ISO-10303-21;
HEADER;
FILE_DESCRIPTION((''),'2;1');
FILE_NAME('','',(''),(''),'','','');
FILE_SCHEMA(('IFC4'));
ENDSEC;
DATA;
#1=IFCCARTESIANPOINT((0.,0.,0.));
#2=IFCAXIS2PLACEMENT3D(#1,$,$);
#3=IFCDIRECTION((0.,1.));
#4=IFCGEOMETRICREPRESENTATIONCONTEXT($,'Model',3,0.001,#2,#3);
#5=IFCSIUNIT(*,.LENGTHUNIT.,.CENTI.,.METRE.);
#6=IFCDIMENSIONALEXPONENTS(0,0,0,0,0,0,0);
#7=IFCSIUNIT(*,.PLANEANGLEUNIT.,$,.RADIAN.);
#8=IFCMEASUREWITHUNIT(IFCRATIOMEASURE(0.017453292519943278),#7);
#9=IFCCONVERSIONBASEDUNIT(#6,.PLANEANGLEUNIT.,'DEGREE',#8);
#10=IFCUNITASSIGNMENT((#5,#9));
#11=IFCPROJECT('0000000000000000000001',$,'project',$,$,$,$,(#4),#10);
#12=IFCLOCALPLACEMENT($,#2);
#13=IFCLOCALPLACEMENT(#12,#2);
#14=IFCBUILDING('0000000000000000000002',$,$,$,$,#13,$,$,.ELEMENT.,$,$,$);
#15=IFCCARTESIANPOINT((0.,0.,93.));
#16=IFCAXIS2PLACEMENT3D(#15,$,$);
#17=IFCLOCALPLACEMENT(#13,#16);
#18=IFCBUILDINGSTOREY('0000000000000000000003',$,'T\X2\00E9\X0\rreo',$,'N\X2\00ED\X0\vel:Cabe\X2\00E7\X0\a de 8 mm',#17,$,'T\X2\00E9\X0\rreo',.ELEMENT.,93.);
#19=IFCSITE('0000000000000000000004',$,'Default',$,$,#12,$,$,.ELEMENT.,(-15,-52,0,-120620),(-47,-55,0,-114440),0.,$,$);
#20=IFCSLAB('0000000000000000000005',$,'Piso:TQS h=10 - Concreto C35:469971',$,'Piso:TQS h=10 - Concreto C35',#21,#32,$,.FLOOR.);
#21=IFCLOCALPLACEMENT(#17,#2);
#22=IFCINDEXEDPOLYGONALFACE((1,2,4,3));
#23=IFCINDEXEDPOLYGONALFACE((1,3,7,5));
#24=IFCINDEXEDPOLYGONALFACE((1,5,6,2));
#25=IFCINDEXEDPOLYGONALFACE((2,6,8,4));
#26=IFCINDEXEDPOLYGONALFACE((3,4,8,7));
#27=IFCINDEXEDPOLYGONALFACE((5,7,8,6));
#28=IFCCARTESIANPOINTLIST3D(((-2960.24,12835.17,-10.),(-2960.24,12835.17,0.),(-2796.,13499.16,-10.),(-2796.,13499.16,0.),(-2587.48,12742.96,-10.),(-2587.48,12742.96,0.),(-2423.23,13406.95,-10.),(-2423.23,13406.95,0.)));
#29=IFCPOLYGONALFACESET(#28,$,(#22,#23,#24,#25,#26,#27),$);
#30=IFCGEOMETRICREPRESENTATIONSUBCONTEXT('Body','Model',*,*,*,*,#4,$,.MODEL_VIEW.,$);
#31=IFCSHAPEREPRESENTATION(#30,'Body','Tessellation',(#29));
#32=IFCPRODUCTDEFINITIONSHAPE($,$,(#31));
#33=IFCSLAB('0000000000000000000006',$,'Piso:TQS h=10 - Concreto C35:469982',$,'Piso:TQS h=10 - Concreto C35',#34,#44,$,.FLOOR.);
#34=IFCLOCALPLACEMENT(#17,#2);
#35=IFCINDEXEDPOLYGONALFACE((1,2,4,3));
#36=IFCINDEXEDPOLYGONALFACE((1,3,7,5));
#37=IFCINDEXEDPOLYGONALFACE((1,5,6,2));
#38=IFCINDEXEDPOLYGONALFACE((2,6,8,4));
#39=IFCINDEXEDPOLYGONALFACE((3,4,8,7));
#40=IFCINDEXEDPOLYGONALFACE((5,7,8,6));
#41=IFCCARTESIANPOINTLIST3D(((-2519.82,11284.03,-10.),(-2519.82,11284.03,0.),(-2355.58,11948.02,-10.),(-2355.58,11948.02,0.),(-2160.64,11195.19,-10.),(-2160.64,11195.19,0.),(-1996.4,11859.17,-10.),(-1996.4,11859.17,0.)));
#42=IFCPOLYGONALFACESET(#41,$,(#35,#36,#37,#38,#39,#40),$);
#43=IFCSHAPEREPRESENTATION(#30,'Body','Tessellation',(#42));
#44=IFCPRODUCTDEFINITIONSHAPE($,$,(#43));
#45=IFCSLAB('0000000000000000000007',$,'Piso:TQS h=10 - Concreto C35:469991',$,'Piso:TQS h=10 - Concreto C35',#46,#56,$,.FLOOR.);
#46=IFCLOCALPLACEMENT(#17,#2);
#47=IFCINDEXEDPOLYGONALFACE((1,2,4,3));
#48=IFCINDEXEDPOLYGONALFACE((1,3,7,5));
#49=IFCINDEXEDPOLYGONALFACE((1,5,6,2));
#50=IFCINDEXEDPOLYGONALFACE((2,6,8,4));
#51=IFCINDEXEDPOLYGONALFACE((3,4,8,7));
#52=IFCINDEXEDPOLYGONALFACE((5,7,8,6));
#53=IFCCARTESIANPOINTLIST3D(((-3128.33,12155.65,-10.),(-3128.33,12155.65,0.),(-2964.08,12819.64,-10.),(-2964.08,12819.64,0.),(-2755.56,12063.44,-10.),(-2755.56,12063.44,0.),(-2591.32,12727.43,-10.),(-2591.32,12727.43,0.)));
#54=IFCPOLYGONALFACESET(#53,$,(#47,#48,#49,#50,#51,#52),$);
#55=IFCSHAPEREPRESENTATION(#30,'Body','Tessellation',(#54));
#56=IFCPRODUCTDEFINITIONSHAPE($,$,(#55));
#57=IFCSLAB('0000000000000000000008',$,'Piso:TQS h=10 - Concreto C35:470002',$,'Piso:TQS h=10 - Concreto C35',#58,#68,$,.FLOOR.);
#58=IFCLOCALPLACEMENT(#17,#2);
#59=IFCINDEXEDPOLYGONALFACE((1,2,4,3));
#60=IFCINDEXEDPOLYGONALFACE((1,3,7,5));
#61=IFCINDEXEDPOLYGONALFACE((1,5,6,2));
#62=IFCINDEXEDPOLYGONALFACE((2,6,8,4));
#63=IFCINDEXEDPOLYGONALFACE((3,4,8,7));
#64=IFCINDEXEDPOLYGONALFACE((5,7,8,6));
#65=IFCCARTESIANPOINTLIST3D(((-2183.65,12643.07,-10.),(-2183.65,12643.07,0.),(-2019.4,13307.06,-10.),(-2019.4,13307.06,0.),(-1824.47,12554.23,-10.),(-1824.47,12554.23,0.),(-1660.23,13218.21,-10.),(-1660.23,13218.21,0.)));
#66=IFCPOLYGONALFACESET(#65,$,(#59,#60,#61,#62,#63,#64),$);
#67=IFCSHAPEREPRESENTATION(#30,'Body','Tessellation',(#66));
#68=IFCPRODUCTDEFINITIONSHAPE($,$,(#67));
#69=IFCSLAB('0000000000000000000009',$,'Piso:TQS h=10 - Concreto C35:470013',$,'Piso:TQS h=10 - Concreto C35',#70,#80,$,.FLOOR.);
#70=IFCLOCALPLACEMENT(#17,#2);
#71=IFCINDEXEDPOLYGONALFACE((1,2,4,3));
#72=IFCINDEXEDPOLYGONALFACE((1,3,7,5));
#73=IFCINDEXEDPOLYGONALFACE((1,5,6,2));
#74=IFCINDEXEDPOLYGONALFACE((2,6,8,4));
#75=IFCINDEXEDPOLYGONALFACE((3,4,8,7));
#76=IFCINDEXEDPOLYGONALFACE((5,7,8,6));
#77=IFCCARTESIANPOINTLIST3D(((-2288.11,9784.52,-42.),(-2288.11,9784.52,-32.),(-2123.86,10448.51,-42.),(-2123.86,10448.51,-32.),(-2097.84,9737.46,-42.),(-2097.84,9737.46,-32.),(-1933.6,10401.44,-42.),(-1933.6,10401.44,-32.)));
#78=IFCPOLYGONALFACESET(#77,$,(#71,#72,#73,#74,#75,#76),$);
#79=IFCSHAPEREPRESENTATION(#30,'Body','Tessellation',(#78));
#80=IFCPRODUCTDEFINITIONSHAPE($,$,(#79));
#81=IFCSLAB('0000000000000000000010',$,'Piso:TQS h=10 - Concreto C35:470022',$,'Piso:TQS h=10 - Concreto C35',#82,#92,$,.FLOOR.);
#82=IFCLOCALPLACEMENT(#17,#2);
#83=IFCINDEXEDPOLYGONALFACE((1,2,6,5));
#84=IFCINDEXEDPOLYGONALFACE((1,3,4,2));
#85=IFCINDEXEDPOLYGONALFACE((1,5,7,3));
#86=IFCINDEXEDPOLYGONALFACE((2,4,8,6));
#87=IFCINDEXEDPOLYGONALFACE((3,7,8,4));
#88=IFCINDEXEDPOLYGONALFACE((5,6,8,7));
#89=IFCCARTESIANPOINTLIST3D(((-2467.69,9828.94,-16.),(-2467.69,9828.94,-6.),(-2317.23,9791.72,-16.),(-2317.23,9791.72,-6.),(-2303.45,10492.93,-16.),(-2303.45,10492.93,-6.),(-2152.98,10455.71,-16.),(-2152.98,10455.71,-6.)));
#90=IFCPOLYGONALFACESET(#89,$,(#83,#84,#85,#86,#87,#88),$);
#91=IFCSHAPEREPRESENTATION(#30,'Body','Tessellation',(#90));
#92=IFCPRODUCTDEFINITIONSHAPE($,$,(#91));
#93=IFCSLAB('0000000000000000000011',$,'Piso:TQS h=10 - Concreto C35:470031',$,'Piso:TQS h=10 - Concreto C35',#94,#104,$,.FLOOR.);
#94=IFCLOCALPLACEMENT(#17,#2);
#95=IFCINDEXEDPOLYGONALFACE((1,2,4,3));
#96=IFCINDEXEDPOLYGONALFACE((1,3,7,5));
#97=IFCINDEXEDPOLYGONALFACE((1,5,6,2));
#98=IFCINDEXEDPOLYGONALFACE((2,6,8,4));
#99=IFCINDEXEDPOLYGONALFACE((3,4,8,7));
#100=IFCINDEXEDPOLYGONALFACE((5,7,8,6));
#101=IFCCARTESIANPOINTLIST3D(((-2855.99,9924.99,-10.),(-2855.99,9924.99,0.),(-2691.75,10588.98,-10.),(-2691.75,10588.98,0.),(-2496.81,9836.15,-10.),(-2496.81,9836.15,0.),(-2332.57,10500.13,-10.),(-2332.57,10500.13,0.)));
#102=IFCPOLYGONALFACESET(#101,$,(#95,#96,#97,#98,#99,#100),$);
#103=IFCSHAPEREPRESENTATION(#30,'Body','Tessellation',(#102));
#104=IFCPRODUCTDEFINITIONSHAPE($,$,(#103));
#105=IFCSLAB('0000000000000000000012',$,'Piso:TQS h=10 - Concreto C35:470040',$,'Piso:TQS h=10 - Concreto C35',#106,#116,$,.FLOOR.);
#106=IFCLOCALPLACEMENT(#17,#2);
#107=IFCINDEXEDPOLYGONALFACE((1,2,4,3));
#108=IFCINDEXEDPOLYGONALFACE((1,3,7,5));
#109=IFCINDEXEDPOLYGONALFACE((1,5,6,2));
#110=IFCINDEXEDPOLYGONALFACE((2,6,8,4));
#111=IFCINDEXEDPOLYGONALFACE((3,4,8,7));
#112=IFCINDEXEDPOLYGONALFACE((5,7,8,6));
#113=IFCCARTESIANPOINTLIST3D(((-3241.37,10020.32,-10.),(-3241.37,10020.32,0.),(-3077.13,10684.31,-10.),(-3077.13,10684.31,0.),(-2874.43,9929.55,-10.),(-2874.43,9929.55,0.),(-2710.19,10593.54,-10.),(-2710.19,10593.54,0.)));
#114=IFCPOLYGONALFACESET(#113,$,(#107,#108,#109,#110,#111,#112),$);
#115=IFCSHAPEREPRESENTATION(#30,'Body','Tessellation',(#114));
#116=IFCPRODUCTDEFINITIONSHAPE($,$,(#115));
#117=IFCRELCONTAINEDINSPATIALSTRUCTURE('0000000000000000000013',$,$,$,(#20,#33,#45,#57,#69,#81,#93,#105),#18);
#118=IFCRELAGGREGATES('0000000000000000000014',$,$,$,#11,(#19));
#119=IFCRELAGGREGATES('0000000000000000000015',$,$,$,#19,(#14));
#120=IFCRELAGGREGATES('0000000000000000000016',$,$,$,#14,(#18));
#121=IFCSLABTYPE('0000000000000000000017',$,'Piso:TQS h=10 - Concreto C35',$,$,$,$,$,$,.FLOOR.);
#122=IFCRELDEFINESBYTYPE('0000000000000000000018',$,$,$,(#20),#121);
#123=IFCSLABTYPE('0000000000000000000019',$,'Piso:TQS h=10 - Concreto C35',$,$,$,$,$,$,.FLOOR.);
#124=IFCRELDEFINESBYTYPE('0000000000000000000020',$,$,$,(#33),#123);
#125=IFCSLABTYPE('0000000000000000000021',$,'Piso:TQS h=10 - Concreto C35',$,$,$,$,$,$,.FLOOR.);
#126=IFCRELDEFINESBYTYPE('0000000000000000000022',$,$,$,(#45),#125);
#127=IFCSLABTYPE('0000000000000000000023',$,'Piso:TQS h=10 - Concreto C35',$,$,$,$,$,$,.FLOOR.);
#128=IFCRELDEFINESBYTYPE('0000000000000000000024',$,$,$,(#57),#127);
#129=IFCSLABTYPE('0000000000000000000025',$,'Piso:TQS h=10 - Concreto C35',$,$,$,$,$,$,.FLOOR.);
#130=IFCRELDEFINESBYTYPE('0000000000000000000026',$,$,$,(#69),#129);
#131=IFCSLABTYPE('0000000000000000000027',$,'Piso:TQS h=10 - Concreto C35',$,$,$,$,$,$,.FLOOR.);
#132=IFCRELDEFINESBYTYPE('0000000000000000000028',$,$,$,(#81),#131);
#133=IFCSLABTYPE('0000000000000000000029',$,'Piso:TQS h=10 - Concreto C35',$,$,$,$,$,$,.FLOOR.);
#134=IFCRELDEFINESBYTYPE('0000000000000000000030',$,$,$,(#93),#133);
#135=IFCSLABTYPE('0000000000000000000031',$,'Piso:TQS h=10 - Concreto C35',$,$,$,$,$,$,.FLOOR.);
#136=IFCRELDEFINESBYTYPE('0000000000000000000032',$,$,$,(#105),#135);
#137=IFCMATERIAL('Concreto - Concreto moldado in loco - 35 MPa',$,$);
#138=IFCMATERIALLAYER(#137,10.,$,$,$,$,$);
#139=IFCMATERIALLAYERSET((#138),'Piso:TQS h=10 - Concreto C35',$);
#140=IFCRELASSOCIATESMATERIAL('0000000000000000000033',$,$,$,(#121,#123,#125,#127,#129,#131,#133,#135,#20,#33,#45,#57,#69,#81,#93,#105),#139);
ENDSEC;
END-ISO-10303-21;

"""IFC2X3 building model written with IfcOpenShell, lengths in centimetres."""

from ifc_helpers import new_model, entity, si_unit, converted_unit, direction, frame, frame_2d, origin, origin_2d_with_axis, place, context, subcontext, project, spatial, rectangle, extrude, material, layer, layer_set, layer_usage, type_object, element, save


model = new_model("IFC2X3")

# Units and contexts
model_context = context("Model", 3, precision=0.001, world=origin(), true_north=direction((0.0, 1.0)))
body_context = subcontext(model_context, "Body", "Model", "MODEL_VIEW")
ifc_project = project(units=[si_unit("LENGTHUNIT", "METRE", prefix="CENTI"), converted_unit("PLANEANGLEUNIT", "DEGREE", entity("IfcRatioMeasure", 0.017453292519943278), si_unit("PLANEANGLEUNIT", "RADIAN"), dimensions=[0, 0, 0, 0, 0, 0, 0])], contexts=[model_context])

# Site, building, storey
site_placement = place(None, origin())
site = spatial("IfcSite", under=ifc_project, at=site_placement, Name="Default", CompositionType="ELEMENT", RefLatitude=(-15, -52, 0, -120620), RefLongitude=(-47, -55, 0, -114440), RefElevation=0.0)
building_placement = place(site_placement, origin())
building = spatial("IfcBuilding", under=site, at=building_placement, CompositionType="ELEMENT")
storey_placement = place(building_placement, frame((0.0, 0.0, 93.0)))
storey = spatial("IfcBuildingStorey", under=building, at=storey_placement, Name="Térreo", ObjectType="Nível:Cabeça de 8 mm", LongName="Térreo", CompositionType="ELEMENT", Elevation=93.0)

# Shared definitions
ifc_material = material(Name="Concreto - Concreto moldado in loco - 35 MPa")

# Slabs
ifc_layer = layer(ifc_material, 10.0)
ifc_layer_set = layer_set([ifc_layer], Name="Piso:TQS h=10 - Concreto C35")
ifc_layer_usage_1 = layer_usage(ifc_layer_set, "AXIS3", "POSITIVE", 0.0)
slab_type_1 = type_object("IfcSlabType", Name="Piso:TQS h=10 - Concreto C35", PredefinedType="FLOOR", material=ifc_layer_set)
slab_1_placement = place(storey_placement, origin())
element("IfcSlab", 1, at=slab_1_placement, inside=storey, type_object=slab_type_1, material=ifc_layer_usage_1, Name="Piso:TQS h=10 - Concreto C35:469971", ObjectType="Piso:TQS h=10 - Concreto C35", PredefinedType="FLOOR", context=body_context, shape_type="SweptSolid", body=[
    extrude(rectangle(XDim=384.0, YDim=684.0, at=frame_2d((0.0, 0.0), x_axis=(1.0, 0.0))), frame((-2691.74, 13121.06, 0.0), z_axis=(0.0, 0.0, -1.0), x_axis=(0.970743, -0.240122, 0.0)), (0.0, 0.0, 1.0), 10.0),
])
ifc_layer_usage_2 = layer_usage(ifc_layer_set, "AXIS3", "POSITIVE", 0.0)
slab_type_2 = type_object("IfcSlabType", Name="Piso:TQS h=10 - Concreto C35", PredefinedType="FLOOR", material=ifc_layer_set)
slab_2_placement = place(storey_placement, origin())
element("IfcSlab", 2, at=slab_2_placement, inside=storey, type_object=slab_type_2, material=ifc_layer_usage_2, Name="Piso:TQS h=10 - Concreto C35:469982", ObjectType="Piso:TQS h=10 - Concreto C35", PredefinedType="FLOOR", context=body_context, shape_type="SweptSolid", body=[
    extrude(rectangle(XDim=684.0, YDim=370.0, at=frame_2d((0.0, 0.0), x_axis=(1.0, 0.0))), frame((-2258.11, 11571.6, 0.0), z_axis=(0.0, 0.0, -1.0), x_axis=(-0.240122, -0.970743, 0.0)), (0.0, 0.0, 1.0), 10.0),
])
ifc_layer_usage_3 = layer_usage(ifc_layer_set, "AXIS3", "POSITIVE", 0.0)
slab_type_3 = type_object("IfcSlabType", Name="Piso:TQS h=10 - Concreto C35", PredefinedType="FLOOR", material=ifc_layer_set)
slab_3_placement = place(storey_placement, origin())
element("IfcSlab", 3, at=slab_3_placement, inside=storey, type_object=slab_type_3, material=ifc_layer_usage_3, Name="Piso:TQS h=10 - Concreto C35:469991", ObjectType="Piso:TQS h=10 - Concreto C35", PredefinedType="FLOOR", context=body_context, shape_type="SweptSolid", body=[
    extrude(rectangle(XDim=684.0, YDim=384.0, at=origin_2d_with_axis()), frame((-2859.82, 12441.54, 0.0), z_axis=(0.0, 0.0, -1.0), x_axis=(-0.240122, -0.970743, 0.0)), (0.0, 0.0, 1.0), 10.0),
])
ifc_layer_usage_4 = layer_usage(ifc_layer_set, "AXIS3", "POSITIVE", 0.0)
slab_type_4 = type_object("IfcSlabType", Name="Piso:TQS h=10 - Concreto C35", PredefinedType="FLOOR", material=ifc_layer_set)
slab_4_placement = place(storey_placement, origin())
element("IfcSlab", 4, at=slab_4_placement, inside=storey, type_object=slab_type_4, material=ifc_layer_usage_4, Name="Piso:TQS h=10 - Concreto C35:470002", ObjectType="Piso:TQS h=10 - Concreto C35", PredefinedType="FLOOR", context=body_context, shape_type="SweptSolid", body=[
    extrude(rectangle(XDim=684.0, YDim=370.0, at=frame_2d((0.0, 0.0), x_axis=(1.0, 0.0))), frame((-1921.94, 12930.64, 0.0), z_axis=(0.0, 0.0, -1.0), x_axis=(-0.240122, -0.970743, 0.0)), (0.0, 0.0, 1.0), 10.0),
])
ifc_layer_usage_5 = layer_usage(ifc_layer_set, "AXIS3", "POSITIVE", 0.0)
slab_type_5 = type_object("IfcSlabType", Name="Piso:TQS h=10 - Concreto C35", PredefinedType="FLOOR", material=ifc_layer_set)
slab_5_placement = place(storey_placement, origin())
element("IfcSlab", 5, at=slab_5_placement, inside=storey, type_object=slab_type_5, material=ifc_layer_usage_5, Name="Piso:TQS h=10 - Concreto C35:470013", ObjectType="Piso:TQS h=10 - Concreto C35", PredefinedType="FLOOR", context=body_context, shape_type="SweptSolid", body=[
    extrude(rectangle(XDim=196.0, YDim=684.0, at=frame_2d((0.0, 0.0), x_axis=(1.0, 0.0))), frame((-2110.85, 10092.98, -32.0), z_axis=(0.0, 0.0, -1.0), x_axis=(0.970743, -0.240122, 0.0)), (0.0, 0.0, 1.0), 10.0),
])
ifc_layer_usage_6 = layer_usage(ifc_layer_set, "AXIS3", "POSITIVE", 0.0)
slab_type_6 = type_object("IfcSlabType", Name="Piso:TQS h=10 - Concreto C35", PredefinedType="FLOOR", material=ifc_layer_set)
slab_6_placement = place(storey_placement, origin())
element("IfcSlab", 6, at=slab_6_placement, inside=storey, type_object=slab_type_6, material=ifc_layer_usage_6, Name="Piso:TQS h=10 - Concreto C35:470022", ObjectType="Piso:TQS h=10 - Concreto C35", PredefinedType="FLOOR", context=body_context, shape_type="SweptSolid", body=[
    extrude(rectangle(XDim=155.0, YDim=684.0, at=origin_2d_with_axis()), frame((-2310.34, 10142.33, -6.0), z_axis=(0.0, 0.0, -1.0), x_axis=(0.970743, -0.240122, 0.0)), (0.0, 0.0, 1.0), 10.0),
])
ifc_layer_usage_7 = layer_usage(ifc_layer_set, "AXIS3", "POSITIVE", 0.0)
slab_type_7 = type_object("IfcSlabType", Name="Piso:TQS h=10 - Concreto C35", PredefinedType="FLOOR", material=ifc_layer_set)
slab_7_placement = place(storey_placement, origin())
element("IfcSlab", 7, at=slab_7_placement, inside=storey, type_object=slab_type_7, material=ifc_layer_usage_7, Name="Piso:TQS h=10 - Concreto C35:470031", ObjectType="Piso:TQS h=10 - Concreto C35", PredefinedType="FLOOR", context=body_context, shape_type="SweptSolid", body=[
    extrude(rectangle(XDim=370.0, YDim=684.0, at=frame_2d((0.0, 0.0), x_axis=(1.0, 0.0))), frame((-2594.28, 10212.56, 0.0), z_axis=(0.0, 0.0, -1.0), x_axis=(0.970743, -0.240122, 0.0)), (0.0, 0.0, 1.0), 10.0),
])
ifc_layer_usage_8 = layer_usage(ifc_layer_set, "AXIS3", "POSITIVE", 0.0)
slab_type_8 = type_object("IfcSlabType", Name="Piso:TQS h=10 - Concreto C35", PredefinedType="FLOOR", material=ifc_layer_set)
slab_8_placement = place(storey_placement, origin())
element("IfcSlab", 8, at=slab_8_placement, inside=storey, type_object=slab_type_8, material=ifc_layer_usage_8, Name="Piso:TQS h=10 - Concreto C35:470040", ObjectType="Piso:TQS h=10 - Concreto C35", PredefinedType="FLOOR", context=body_context, shape_type="SweptSolid", body=[
    extrude(rectangle(XDim=378.0, YDim=684.0, at=origin_2d_with_axis()), frame((-2975.78, 10306.93, 0.0), z_axis=(0.0, 0.0, -1.0), x_axis=(0.970743, -0.240122, 0.0)), (0.0, 0.0, 1.0), 10.0),
])

save(model, "model.ifc")
